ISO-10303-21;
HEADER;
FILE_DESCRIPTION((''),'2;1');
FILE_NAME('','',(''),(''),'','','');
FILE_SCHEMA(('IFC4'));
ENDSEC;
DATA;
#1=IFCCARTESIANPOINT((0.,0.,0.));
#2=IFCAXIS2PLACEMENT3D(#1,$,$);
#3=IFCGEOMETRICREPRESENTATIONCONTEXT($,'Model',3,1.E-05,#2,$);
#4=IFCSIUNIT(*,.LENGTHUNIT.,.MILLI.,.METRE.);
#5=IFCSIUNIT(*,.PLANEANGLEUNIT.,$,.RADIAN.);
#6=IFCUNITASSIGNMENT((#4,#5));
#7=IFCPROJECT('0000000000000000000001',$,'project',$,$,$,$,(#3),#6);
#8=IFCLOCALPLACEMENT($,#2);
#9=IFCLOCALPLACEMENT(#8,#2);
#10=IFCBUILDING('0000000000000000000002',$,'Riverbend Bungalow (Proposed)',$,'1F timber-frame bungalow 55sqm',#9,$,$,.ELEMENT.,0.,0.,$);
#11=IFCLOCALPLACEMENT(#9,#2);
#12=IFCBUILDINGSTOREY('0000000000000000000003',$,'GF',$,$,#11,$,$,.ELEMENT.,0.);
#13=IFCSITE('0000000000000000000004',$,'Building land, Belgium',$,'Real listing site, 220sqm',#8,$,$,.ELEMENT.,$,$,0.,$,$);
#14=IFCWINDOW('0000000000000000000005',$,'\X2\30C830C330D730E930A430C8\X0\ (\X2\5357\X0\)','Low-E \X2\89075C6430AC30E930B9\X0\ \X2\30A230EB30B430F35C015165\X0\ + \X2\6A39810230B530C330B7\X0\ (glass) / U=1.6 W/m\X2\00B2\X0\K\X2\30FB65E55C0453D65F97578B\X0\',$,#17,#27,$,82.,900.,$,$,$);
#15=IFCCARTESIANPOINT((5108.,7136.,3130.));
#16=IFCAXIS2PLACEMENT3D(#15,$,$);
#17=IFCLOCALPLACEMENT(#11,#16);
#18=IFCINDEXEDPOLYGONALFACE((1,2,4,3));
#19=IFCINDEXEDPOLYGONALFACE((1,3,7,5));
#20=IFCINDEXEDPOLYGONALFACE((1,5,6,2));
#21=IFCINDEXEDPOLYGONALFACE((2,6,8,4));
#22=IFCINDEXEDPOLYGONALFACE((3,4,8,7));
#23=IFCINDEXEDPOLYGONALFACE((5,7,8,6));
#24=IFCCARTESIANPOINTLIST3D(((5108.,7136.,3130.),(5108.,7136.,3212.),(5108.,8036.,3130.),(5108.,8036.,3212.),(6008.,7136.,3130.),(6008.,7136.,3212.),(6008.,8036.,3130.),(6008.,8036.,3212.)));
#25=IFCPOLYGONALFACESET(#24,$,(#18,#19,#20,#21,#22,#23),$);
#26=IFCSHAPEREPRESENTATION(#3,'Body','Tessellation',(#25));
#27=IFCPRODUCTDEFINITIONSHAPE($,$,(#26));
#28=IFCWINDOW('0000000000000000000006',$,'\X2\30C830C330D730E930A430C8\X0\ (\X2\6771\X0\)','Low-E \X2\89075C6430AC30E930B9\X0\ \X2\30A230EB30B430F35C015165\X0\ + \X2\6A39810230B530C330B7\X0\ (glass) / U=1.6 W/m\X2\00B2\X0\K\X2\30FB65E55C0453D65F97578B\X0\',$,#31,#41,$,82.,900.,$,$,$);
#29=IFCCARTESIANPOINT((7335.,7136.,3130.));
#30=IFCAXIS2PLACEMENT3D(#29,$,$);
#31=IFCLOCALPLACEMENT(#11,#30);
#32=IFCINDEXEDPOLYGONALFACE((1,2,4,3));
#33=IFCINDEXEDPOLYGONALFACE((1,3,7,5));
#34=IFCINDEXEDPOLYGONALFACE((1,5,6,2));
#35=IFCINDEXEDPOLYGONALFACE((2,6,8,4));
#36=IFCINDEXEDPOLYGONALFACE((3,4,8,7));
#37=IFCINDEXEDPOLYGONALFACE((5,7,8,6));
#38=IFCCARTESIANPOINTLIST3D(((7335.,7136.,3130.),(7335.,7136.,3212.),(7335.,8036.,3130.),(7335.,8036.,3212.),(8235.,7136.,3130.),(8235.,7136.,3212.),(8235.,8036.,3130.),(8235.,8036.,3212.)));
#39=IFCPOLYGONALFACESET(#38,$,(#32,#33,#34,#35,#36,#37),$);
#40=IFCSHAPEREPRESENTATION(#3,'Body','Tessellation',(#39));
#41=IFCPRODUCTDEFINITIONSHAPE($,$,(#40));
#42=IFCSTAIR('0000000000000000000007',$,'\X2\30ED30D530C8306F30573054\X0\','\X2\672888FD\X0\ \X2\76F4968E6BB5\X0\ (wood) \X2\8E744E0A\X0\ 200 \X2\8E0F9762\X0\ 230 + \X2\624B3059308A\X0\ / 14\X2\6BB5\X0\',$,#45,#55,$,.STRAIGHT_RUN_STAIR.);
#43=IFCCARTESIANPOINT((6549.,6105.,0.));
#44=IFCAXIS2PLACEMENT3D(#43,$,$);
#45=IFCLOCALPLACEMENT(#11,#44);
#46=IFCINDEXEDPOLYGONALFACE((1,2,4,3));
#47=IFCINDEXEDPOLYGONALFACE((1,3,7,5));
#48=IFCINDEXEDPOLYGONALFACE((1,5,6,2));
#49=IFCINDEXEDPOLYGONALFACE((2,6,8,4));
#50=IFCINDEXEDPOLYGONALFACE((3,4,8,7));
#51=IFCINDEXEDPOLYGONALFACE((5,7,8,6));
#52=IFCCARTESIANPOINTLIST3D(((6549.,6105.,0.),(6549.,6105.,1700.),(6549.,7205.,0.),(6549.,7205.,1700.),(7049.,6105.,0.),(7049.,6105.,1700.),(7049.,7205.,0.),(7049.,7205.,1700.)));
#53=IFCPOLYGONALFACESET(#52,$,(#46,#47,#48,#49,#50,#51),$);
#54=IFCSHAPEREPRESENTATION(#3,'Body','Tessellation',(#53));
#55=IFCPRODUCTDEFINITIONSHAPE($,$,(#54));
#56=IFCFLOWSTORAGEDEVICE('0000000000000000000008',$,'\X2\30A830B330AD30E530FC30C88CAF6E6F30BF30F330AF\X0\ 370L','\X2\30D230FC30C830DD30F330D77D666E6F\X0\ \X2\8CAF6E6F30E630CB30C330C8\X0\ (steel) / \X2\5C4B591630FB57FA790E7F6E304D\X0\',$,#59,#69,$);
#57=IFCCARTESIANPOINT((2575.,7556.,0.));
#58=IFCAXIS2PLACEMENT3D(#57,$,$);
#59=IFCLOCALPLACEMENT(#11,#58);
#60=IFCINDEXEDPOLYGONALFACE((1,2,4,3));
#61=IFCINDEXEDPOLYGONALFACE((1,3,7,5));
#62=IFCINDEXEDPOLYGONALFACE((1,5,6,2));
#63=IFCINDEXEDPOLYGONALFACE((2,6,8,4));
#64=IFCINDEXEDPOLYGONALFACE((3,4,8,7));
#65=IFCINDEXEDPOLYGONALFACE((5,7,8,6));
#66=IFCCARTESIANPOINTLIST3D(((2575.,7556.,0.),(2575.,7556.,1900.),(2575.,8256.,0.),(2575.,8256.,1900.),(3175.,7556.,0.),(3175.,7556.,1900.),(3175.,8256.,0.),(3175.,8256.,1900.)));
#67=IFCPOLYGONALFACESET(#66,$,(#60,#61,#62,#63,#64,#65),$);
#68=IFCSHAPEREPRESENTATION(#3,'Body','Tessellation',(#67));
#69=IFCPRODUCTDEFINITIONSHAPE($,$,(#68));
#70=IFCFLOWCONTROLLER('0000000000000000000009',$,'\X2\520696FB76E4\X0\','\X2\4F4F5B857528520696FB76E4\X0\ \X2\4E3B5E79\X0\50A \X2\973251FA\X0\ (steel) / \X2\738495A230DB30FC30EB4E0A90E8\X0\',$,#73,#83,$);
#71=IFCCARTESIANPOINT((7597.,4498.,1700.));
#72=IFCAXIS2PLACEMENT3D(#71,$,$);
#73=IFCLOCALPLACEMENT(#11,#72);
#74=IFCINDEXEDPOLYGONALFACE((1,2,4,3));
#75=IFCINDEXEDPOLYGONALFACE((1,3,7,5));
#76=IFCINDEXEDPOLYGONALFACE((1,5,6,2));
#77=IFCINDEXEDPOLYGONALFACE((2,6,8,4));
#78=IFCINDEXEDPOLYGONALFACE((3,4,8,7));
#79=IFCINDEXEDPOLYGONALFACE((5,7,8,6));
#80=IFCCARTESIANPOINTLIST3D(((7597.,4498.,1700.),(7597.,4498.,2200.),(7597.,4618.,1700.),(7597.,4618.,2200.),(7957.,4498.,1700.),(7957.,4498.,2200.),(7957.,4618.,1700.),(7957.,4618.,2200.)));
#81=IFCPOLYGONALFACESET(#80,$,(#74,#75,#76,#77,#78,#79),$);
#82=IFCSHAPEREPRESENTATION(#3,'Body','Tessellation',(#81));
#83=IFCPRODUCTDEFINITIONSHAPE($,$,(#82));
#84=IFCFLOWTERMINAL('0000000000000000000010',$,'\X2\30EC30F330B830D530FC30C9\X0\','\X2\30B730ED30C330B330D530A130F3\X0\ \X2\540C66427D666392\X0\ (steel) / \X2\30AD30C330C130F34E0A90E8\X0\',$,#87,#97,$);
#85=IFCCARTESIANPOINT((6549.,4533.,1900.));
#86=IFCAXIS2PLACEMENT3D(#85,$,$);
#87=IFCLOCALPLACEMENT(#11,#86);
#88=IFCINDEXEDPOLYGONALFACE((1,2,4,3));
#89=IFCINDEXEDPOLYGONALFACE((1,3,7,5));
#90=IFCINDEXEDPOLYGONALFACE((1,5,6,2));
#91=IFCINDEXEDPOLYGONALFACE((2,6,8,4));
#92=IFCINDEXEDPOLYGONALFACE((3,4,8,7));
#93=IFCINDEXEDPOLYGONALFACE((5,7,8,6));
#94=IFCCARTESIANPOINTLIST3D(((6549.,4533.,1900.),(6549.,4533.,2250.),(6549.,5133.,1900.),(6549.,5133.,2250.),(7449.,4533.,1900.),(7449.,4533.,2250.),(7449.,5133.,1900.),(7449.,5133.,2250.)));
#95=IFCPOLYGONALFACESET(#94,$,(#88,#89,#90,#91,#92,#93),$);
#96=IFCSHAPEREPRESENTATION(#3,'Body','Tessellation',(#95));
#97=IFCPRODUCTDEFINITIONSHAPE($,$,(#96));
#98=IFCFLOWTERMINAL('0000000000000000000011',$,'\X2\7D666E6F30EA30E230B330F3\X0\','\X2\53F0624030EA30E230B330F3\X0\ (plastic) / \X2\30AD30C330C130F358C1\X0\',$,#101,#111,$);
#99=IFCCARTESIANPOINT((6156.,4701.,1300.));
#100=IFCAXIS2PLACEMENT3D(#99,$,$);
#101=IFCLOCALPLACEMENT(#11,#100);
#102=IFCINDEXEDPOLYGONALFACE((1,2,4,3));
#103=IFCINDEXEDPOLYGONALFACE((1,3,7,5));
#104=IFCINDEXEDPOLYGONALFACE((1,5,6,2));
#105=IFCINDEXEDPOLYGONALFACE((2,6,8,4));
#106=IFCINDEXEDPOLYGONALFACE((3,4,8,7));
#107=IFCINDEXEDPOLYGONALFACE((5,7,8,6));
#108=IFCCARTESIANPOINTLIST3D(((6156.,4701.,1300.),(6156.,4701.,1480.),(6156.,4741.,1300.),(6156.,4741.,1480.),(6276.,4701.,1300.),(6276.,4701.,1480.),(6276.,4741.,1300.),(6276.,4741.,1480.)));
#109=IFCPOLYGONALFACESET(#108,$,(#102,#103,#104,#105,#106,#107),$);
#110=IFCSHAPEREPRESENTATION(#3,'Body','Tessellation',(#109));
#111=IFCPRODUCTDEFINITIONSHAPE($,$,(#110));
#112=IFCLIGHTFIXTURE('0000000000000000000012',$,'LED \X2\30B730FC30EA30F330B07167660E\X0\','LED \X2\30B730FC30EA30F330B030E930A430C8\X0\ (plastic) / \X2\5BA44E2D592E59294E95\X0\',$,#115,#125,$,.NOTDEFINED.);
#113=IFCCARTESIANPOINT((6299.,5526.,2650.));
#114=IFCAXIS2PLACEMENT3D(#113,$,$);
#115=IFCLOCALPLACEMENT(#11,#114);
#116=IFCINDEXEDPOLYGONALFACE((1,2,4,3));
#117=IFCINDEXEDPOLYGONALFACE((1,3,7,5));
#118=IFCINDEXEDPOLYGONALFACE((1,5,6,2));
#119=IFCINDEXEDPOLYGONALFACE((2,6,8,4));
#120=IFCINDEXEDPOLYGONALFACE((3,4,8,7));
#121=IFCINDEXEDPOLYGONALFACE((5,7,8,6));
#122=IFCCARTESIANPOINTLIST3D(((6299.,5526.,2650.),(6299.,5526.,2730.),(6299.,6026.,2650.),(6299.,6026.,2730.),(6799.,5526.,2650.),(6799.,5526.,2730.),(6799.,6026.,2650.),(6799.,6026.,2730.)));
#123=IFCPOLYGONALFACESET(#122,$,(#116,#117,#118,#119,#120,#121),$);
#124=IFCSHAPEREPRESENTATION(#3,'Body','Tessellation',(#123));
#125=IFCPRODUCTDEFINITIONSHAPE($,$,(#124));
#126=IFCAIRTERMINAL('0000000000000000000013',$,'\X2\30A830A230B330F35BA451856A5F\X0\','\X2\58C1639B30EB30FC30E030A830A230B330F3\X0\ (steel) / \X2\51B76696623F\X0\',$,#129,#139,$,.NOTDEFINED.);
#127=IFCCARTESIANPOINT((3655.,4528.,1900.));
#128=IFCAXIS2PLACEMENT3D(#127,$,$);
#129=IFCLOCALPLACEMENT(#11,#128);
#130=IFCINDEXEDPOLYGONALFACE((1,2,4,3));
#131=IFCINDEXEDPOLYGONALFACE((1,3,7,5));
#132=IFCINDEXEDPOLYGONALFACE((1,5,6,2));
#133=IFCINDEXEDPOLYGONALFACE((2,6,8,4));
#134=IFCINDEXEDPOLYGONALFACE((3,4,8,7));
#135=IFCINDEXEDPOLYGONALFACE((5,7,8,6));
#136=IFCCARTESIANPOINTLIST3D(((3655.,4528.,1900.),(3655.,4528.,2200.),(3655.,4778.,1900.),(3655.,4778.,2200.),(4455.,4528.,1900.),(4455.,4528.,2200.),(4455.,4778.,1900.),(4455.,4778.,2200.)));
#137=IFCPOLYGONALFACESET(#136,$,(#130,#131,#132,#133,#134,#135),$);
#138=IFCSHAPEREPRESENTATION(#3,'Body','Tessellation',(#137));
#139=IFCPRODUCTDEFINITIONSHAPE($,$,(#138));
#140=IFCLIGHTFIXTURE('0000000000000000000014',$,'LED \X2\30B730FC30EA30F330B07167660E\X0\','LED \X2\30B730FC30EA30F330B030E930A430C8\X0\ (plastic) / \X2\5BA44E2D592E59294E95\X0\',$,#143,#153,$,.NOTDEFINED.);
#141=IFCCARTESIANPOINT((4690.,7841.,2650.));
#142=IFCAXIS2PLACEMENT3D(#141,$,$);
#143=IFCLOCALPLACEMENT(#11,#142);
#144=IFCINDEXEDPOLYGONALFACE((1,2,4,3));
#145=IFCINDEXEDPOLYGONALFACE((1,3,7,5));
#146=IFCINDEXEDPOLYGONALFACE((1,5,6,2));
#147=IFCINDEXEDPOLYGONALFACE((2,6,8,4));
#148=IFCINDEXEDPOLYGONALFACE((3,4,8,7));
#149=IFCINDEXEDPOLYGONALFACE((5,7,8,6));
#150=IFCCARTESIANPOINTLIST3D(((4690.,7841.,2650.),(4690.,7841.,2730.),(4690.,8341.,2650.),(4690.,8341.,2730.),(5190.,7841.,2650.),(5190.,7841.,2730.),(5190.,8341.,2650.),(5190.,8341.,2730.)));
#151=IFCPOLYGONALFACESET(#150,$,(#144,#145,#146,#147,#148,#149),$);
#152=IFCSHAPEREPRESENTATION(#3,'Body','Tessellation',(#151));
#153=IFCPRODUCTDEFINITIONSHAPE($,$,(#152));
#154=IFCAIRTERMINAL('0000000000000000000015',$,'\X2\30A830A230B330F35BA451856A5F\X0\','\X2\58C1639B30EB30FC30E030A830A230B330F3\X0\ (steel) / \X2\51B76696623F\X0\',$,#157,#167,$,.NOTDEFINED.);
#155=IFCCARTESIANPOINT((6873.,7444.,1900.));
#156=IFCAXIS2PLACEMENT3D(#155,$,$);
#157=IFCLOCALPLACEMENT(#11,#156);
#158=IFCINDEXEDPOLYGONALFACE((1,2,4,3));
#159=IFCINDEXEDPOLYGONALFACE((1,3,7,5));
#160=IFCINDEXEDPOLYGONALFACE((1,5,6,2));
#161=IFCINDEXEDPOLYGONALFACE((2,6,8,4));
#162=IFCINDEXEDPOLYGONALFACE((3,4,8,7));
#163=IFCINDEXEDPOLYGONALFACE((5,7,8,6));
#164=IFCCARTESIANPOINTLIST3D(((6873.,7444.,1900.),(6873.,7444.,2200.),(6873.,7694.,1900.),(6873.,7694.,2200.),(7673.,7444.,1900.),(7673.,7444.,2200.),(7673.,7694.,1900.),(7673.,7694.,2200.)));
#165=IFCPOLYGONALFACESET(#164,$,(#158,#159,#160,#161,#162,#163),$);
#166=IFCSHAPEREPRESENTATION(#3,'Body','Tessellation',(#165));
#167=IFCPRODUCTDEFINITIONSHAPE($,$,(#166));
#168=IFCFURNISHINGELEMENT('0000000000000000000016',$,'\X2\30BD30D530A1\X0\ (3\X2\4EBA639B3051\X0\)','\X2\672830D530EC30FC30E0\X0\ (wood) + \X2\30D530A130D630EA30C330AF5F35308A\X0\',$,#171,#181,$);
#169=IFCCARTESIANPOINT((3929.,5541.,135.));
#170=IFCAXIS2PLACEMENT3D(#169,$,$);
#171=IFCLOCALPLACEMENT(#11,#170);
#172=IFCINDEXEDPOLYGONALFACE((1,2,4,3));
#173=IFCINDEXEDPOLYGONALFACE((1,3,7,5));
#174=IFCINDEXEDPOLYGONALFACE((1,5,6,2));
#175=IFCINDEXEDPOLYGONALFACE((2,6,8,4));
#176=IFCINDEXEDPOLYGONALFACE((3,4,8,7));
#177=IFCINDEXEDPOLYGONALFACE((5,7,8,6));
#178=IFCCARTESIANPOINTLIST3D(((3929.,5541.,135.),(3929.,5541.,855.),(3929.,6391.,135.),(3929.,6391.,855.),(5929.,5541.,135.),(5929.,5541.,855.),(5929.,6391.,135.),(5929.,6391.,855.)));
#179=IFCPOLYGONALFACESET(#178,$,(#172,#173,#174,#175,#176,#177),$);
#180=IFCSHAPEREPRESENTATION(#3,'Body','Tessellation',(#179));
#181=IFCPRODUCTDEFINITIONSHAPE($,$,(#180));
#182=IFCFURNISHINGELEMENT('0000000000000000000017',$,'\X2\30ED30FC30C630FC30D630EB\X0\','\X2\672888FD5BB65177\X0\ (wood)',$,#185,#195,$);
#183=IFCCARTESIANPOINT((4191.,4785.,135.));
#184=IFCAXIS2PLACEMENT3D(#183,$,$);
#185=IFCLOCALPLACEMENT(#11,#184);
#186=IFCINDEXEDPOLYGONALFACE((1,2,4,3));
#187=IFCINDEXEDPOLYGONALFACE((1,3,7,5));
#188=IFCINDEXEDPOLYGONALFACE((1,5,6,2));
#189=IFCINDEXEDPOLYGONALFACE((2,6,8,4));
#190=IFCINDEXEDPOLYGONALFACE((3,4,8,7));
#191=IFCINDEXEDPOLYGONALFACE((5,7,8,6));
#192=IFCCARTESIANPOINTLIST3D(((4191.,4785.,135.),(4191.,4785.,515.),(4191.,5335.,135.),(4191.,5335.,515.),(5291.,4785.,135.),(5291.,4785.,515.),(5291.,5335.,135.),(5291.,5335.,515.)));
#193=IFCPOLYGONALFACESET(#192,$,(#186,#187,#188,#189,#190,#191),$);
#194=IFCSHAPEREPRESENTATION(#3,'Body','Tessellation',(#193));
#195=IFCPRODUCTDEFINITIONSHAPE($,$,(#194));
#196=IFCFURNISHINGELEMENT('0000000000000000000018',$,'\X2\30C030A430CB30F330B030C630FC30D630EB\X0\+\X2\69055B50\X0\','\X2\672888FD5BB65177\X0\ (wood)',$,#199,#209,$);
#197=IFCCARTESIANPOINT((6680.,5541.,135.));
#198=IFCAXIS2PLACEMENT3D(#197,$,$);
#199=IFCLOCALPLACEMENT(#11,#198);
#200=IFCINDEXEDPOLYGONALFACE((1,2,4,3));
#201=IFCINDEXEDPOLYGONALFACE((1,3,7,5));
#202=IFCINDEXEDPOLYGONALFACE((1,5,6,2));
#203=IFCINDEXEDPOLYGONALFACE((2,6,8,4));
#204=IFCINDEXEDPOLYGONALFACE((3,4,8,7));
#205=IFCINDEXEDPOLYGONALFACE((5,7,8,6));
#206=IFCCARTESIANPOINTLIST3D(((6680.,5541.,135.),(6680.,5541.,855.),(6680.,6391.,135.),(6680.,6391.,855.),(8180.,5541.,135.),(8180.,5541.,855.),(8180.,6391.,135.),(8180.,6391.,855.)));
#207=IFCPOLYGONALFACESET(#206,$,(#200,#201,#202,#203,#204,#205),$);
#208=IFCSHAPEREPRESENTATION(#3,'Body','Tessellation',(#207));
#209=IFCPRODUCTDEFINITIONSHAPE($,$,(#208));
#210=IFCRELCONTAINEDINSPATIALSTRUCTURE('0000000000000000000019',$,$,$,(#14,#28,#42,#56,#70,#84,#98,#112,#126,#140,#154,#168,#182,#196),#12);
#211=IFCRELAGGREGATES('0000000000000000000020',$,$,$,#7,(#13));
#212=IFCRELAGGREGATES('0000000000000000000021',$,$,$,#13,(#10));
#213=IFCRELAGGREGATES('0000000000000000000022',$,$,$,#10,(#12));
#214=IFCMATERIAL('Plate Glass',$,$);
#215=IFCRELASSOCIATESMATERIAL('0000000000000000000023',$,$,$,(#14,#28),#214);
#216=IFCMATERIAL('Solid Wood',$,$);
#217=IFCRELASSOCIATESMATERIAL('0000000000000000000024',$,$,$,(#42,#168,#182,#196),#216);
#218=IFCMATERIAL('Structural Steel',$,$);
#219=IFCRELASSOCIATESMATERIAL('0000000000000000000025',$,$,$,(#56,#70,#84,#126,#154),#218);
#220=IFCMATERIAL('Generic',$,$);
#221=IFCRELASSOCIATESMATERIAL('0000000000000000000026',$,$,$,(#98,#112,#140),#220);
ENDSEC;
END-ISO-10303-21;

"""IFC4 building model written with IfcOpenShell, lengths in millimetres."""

from ifc_helpers import new_model, si_unit, frame, frame_2d, origin, place, context, project, spatial, rectangle, extrude, material, element, save


model = new_model("IFC4")

# Units and contexts
model_context = context("Model", 3, precision=1e-05, world=origin())
ifc_project = project(units=[si_unit("LENGTHUNIT", "METRE", prefix="MILLI"), si_unit("PLANEANGLEUNIT", "RADIAN")], contexts=[model_context])

# Site, building, storey
site_placement = place(None, origin())
site = spatial("IfcSite", under=ifc_project, at=site_placement, Name="Building land, Belgium", ObjectType="Real listing site, 220sqm", CompositionType="ELEMENT", RefElevation=0.0)
building_placement = place(site_placement, origin())
building = spatial("IfcBuilding", under=site, at=building_placement, Name="Riverbend Bungalow (Proposed)", ObjectType="1F timber-frame bungalow 55sqm", CompositionType="ELEMENT", ElevationOfRefHeight=0.0, ElevationOfTerrain=0.0)
storey_placement = place(building_placement, origin())
storey = spatial("IfcBuildingStorey", under=building, at=storey_placement, Name="GF", CompositionType="ELEMENT", Elevation=0.0)

# Shared definitions
ifc_material_1 = material(Name="Solid Wood")

# Windows
ifc_material_2 = material(Name="Plate Glass")
window_1_placement = place(storey_placement, frame((5108.0, 7136.0, 3130.0)))
element("IfcWindow", 1, at=window_1_placement, inside=storey, material=ifc_material_2, Name="トップライト (南)", Description="Low-E 複層ガラス アルゴン封入 + 樹脂サッシ (glass) / U=1.6 W/m²K・日射取得型", OverallHeight=82.0, OverallWidth=900.0, context=model_context, shape_type="SweptSolid", body=[
    extrude(rectangle(XDim=900.0, YDim=900.0, at=frame_2d((450.0, 450.0))), frame((5108.0, 7136.0, 3130.0)), (0.0, 0.0, 1.0), 82.0),
])
window_2_placement = place(storey_placement, frame((7335.0, 7136.0, 3130.0)))
element("IfcWindow", 2, at=window_2_placement, inside=storey, material=ifc_material_2, Name="トップライト (東)", Description="Low-E 複層ガラス アルゴン封入 + 樹脂サッシ (glass) / U=1.6 W/m²K・日射取得型", OverallHeight=82.0, OverallWidth=900.0, context=model_context, shape_type="SweptSolid", body=[
    extrude(rectangle(XDim=900.0, YDim=900.0, at=frame_2d((450.0, 450.0))), frame((7335.0, 7136.0, 3130.0)), (0.0, 0.0, 1.0), 82.0),
])

# Stair
stair_placement = place(storey_placement, frame((6549.0, 6105.0, 0.0)))
element("IfcStair", 3, at=stair_placement, inside=storey, material=ifc_material_1, Name="ロフトはしご", Description="木製 直階段 (wood) 蹴上 200 踏面 230 + 手すり / 14段", PredefinedType="STRAIGHT_RUN_STAIR", context=model_context, shape_type="SweptSolid", body=[
    extrude(rectangle(XDim=500.0, YDim=1100.0, at=frame_2d((250.0, 550.0))), frame((6549.0, 6105.0, 0.0)), (0.0, 0.0, 1.0), 1700.0),
])

# Flow storage device
ifc_material_3 = material(Name="Structural Steel")
flow_storage_device_placement = place(storey_placement, frame((2575.0, 7556.0, 0.0)))
element("IfcFlowStorageDevice", 4, at=flow_storage_device_placement, inside=storey, material=ifc_material_3, Name="エコキュート貯湯タンク 370L", Description="ヒートポンプ給湯 貯湯ユニット (steel) / 屋外・基礎置き", context=model_context, shape_type="SweptSolid", body=[
    extrude(rectangle(XDim=600.0, YDim=700.0, at=frame_2d((300.0, 350.0))), frame((2575.0, 7556.0, 0.0)), (0.0, 0.0, 1.0), 1900.0),
])

# Flow controller
flow_controller_placement = place(storey_placement, frame((7597.0, 4498.0, 1700.0)))
element("IfcFlowController", 5, at=flow_controller_placement, inside=storey, material=ifc_material_3, Name="分電盤", Description="住宅用分電盤 主幹50A 露出 (steel) / 玄関ホール上部", context=model_context, shape_type="SweptSolid", body=[
    extrude(rectangle(XDim=360.0, YDim=120.0, at=frame_2d((180.0, 60.0))), frame((7597.0, 4498.0, 1700.0)), (0.0, 0.0, 1.0), 500.0),
])

# Flow terminals
flow_terminal_1_placement = place(storey_placement, frame((6549.0, 4533.0, 1900.0)))
element("IfcFlowTerminal", 6, at=flow_terminal_1_placement, inside=storey, material=ifc_material_3, Name="レンジフード", Description="シロッコファン 同時給排 (steel) / キッチン上部", context=model_context, shape_type="SweptSolid", body=[
    extrude(rectangle(XDim=900.0, YDim=600.0, at=frame_2d((450.0, 300.0))), frame((6549.0, 4533.0, 1900.0)), (0.0, 0.0, 1.0), 350.0),
])
ifc_material_4 = material(Name="Generic")
flow_terminal_2_placement = place(storey_placement, frame((6156.0, 4701.0, 1300.0)))
element("IfcFlowTerminal", 7, at=flow_terminal_2_placement, inside=storey, material=ifc_material_4, Name="給湯リモコン", Description="台所リモコン (plastic) / キッチン壁", context=model_context, shape_type="SweptSolid", body=[
    extrude(rectangle(XDim=120.0, YDim=40.0, at=frame_2d((60.0, 20.0))), frame((6156.0, 4701.0, 1300.0)), (0.0, 0.0, 1.0), 180.0),
])

# Light fixture
light_fixture_1_placement = place(storey_placement, frame((6299.0, 5526.0, 2650.0)))
element("IfcLightFixture", 8, at=light_fixture_1_placement, inside=storey, material=ifc_material_4, Name="LED シーリング照明", Description="LED シーリングライト (plastic) / 室中央天井", PredefinedType="NOTDEFINED", context=model_context, shape_type="SweptSolid", body=[
    extrude(rectangle(XDim=500.0, YDim=500.0, at=frame_2d((250.0, 250.0))), frame((6299.0, 5526.0, 2650.0)), (0.0, 0.0, 1.0), 80.0),
])

# Air terminal
air_terminal_1_placement = place(storey_placement, frame((3655.0, 4528.0, 1900.0)))
element("IfcAirTerminal", 9, at=air_terminal_1_placement, inside=storey, material=ifc_material_3, Name="エアコン室内機", Description="壁掛ルームエアコン (steel) / 冷暖房", PredefinedType="NOTDEFINED", context=model_context, shape_type="SweptSolid", body=[
    extrude(rectangle(XDim=800.0, YDim=250.0, at=frame_2d((400.0, 125.0))), frame((3655.0, 4528.0, 1900.0)), (0.0, 0.0, 1.0), 300.0),
])

# Light fixture
light_fixture_2_placement = place(storey_placement, frame((4690.0, 7841.0, 2650.0)))
element("IfcLightFixture", 10, at=light_fixture_2_placement, inside=storey, material=ifc_material_4, Name="LED シーリング照明", Description="LED シーリングライト (plastic) / 室中央天井", PredefinedType="NOTDEFINED", context=model_context, shape_type="SweptSolid", body=[
    extrude(rectangle(XDim=500.0, YDim=500.0, at=frame_2d((250.0, 250.0))), frame((4690.0, 7841.0, 2650.0)), (0.0, 0.0, 1.0), 80.0),
])

# Air terminal
air_terminal_2_placement = place(storey_placement, frame((6873.0, 7444.0, 1900.0)))
element("IfcAirTerminal", 11, at=air_terminal_2_placement, inside=storey, material=ifc_material_3, Name="エアコン室内機", Description="壁掛ルームエアコン (steel) / 冷暖房", PredefinedType="NOTDEFINED", context=model_context, shape_type="SweptSolid", body=[
    extrude(rectangle(XDim=800.0, YDim=250.0, at=frame_2d((400.0, 125.0))), frame((6873.0, 7444.0, 1900.0)), (0.0, 0.0, 1.0), 300.0),
])

# Furnishing elements
furnishing_1_placement = place(storey_placement, frame((3929.0, 5541.0, 135.0)))
element("IfcFurnishingElement", 12, at=furnishing_1_placement, inside=storey, material=ifc_material_1, Name="ソファ (3人掛け)", Description="木フレーム (wood) + ファブリック張り", context=model_context, shape_type="SweptSolid", body=[
    extrude(rectangle(XDim=2000.0, YDim=850.0, at=frame_2d((1000.0, 425.0))), frame((3929.0, 5541.0, 135.0)), (0.0, 0.0, 1.0), 720.0),
])
furnishing_2_placement = place(storey_placement, frame((4191.0, 4785.0, 135.0)))
element("IfcFurnishingElement", 13, at=furnishing_2_placement, inside=storey, material=ifc_material_1, Name="ローテーブル", Description="木製家具 (wood)", context=model_context, shape_type="SweptSolid", body=[
    extrude(rectangle(XDim=1100.0, YDim=550.0, at=frame_2d((550.0, 275.0))), frame((4191.0, 4785.0, 135.0)), (0.0, 0.0, 1.0), 380.0),
])
furnishing_3_placement = place(storey_placement, frame((6680.0, 5541.0, 135.0)))
element("IfcFurnishingElement", 14, at=furnishing_3_placement, inside=storey, material=ifc_material_1, Name="ダイニングテーブル+椅子", Description="木製家具 (wood)", context=model_context, shape_type="SweptSolid", body=[
    extrude(rectangle(XDim=1500.0, YDim=850.0, at=frame_2d((750.0, 425.0))), frame((6680.0, 5541.0, 135.0)), (0.0, 0.0, 1.0), 720.0),
])

save(model, "model.ifc")
